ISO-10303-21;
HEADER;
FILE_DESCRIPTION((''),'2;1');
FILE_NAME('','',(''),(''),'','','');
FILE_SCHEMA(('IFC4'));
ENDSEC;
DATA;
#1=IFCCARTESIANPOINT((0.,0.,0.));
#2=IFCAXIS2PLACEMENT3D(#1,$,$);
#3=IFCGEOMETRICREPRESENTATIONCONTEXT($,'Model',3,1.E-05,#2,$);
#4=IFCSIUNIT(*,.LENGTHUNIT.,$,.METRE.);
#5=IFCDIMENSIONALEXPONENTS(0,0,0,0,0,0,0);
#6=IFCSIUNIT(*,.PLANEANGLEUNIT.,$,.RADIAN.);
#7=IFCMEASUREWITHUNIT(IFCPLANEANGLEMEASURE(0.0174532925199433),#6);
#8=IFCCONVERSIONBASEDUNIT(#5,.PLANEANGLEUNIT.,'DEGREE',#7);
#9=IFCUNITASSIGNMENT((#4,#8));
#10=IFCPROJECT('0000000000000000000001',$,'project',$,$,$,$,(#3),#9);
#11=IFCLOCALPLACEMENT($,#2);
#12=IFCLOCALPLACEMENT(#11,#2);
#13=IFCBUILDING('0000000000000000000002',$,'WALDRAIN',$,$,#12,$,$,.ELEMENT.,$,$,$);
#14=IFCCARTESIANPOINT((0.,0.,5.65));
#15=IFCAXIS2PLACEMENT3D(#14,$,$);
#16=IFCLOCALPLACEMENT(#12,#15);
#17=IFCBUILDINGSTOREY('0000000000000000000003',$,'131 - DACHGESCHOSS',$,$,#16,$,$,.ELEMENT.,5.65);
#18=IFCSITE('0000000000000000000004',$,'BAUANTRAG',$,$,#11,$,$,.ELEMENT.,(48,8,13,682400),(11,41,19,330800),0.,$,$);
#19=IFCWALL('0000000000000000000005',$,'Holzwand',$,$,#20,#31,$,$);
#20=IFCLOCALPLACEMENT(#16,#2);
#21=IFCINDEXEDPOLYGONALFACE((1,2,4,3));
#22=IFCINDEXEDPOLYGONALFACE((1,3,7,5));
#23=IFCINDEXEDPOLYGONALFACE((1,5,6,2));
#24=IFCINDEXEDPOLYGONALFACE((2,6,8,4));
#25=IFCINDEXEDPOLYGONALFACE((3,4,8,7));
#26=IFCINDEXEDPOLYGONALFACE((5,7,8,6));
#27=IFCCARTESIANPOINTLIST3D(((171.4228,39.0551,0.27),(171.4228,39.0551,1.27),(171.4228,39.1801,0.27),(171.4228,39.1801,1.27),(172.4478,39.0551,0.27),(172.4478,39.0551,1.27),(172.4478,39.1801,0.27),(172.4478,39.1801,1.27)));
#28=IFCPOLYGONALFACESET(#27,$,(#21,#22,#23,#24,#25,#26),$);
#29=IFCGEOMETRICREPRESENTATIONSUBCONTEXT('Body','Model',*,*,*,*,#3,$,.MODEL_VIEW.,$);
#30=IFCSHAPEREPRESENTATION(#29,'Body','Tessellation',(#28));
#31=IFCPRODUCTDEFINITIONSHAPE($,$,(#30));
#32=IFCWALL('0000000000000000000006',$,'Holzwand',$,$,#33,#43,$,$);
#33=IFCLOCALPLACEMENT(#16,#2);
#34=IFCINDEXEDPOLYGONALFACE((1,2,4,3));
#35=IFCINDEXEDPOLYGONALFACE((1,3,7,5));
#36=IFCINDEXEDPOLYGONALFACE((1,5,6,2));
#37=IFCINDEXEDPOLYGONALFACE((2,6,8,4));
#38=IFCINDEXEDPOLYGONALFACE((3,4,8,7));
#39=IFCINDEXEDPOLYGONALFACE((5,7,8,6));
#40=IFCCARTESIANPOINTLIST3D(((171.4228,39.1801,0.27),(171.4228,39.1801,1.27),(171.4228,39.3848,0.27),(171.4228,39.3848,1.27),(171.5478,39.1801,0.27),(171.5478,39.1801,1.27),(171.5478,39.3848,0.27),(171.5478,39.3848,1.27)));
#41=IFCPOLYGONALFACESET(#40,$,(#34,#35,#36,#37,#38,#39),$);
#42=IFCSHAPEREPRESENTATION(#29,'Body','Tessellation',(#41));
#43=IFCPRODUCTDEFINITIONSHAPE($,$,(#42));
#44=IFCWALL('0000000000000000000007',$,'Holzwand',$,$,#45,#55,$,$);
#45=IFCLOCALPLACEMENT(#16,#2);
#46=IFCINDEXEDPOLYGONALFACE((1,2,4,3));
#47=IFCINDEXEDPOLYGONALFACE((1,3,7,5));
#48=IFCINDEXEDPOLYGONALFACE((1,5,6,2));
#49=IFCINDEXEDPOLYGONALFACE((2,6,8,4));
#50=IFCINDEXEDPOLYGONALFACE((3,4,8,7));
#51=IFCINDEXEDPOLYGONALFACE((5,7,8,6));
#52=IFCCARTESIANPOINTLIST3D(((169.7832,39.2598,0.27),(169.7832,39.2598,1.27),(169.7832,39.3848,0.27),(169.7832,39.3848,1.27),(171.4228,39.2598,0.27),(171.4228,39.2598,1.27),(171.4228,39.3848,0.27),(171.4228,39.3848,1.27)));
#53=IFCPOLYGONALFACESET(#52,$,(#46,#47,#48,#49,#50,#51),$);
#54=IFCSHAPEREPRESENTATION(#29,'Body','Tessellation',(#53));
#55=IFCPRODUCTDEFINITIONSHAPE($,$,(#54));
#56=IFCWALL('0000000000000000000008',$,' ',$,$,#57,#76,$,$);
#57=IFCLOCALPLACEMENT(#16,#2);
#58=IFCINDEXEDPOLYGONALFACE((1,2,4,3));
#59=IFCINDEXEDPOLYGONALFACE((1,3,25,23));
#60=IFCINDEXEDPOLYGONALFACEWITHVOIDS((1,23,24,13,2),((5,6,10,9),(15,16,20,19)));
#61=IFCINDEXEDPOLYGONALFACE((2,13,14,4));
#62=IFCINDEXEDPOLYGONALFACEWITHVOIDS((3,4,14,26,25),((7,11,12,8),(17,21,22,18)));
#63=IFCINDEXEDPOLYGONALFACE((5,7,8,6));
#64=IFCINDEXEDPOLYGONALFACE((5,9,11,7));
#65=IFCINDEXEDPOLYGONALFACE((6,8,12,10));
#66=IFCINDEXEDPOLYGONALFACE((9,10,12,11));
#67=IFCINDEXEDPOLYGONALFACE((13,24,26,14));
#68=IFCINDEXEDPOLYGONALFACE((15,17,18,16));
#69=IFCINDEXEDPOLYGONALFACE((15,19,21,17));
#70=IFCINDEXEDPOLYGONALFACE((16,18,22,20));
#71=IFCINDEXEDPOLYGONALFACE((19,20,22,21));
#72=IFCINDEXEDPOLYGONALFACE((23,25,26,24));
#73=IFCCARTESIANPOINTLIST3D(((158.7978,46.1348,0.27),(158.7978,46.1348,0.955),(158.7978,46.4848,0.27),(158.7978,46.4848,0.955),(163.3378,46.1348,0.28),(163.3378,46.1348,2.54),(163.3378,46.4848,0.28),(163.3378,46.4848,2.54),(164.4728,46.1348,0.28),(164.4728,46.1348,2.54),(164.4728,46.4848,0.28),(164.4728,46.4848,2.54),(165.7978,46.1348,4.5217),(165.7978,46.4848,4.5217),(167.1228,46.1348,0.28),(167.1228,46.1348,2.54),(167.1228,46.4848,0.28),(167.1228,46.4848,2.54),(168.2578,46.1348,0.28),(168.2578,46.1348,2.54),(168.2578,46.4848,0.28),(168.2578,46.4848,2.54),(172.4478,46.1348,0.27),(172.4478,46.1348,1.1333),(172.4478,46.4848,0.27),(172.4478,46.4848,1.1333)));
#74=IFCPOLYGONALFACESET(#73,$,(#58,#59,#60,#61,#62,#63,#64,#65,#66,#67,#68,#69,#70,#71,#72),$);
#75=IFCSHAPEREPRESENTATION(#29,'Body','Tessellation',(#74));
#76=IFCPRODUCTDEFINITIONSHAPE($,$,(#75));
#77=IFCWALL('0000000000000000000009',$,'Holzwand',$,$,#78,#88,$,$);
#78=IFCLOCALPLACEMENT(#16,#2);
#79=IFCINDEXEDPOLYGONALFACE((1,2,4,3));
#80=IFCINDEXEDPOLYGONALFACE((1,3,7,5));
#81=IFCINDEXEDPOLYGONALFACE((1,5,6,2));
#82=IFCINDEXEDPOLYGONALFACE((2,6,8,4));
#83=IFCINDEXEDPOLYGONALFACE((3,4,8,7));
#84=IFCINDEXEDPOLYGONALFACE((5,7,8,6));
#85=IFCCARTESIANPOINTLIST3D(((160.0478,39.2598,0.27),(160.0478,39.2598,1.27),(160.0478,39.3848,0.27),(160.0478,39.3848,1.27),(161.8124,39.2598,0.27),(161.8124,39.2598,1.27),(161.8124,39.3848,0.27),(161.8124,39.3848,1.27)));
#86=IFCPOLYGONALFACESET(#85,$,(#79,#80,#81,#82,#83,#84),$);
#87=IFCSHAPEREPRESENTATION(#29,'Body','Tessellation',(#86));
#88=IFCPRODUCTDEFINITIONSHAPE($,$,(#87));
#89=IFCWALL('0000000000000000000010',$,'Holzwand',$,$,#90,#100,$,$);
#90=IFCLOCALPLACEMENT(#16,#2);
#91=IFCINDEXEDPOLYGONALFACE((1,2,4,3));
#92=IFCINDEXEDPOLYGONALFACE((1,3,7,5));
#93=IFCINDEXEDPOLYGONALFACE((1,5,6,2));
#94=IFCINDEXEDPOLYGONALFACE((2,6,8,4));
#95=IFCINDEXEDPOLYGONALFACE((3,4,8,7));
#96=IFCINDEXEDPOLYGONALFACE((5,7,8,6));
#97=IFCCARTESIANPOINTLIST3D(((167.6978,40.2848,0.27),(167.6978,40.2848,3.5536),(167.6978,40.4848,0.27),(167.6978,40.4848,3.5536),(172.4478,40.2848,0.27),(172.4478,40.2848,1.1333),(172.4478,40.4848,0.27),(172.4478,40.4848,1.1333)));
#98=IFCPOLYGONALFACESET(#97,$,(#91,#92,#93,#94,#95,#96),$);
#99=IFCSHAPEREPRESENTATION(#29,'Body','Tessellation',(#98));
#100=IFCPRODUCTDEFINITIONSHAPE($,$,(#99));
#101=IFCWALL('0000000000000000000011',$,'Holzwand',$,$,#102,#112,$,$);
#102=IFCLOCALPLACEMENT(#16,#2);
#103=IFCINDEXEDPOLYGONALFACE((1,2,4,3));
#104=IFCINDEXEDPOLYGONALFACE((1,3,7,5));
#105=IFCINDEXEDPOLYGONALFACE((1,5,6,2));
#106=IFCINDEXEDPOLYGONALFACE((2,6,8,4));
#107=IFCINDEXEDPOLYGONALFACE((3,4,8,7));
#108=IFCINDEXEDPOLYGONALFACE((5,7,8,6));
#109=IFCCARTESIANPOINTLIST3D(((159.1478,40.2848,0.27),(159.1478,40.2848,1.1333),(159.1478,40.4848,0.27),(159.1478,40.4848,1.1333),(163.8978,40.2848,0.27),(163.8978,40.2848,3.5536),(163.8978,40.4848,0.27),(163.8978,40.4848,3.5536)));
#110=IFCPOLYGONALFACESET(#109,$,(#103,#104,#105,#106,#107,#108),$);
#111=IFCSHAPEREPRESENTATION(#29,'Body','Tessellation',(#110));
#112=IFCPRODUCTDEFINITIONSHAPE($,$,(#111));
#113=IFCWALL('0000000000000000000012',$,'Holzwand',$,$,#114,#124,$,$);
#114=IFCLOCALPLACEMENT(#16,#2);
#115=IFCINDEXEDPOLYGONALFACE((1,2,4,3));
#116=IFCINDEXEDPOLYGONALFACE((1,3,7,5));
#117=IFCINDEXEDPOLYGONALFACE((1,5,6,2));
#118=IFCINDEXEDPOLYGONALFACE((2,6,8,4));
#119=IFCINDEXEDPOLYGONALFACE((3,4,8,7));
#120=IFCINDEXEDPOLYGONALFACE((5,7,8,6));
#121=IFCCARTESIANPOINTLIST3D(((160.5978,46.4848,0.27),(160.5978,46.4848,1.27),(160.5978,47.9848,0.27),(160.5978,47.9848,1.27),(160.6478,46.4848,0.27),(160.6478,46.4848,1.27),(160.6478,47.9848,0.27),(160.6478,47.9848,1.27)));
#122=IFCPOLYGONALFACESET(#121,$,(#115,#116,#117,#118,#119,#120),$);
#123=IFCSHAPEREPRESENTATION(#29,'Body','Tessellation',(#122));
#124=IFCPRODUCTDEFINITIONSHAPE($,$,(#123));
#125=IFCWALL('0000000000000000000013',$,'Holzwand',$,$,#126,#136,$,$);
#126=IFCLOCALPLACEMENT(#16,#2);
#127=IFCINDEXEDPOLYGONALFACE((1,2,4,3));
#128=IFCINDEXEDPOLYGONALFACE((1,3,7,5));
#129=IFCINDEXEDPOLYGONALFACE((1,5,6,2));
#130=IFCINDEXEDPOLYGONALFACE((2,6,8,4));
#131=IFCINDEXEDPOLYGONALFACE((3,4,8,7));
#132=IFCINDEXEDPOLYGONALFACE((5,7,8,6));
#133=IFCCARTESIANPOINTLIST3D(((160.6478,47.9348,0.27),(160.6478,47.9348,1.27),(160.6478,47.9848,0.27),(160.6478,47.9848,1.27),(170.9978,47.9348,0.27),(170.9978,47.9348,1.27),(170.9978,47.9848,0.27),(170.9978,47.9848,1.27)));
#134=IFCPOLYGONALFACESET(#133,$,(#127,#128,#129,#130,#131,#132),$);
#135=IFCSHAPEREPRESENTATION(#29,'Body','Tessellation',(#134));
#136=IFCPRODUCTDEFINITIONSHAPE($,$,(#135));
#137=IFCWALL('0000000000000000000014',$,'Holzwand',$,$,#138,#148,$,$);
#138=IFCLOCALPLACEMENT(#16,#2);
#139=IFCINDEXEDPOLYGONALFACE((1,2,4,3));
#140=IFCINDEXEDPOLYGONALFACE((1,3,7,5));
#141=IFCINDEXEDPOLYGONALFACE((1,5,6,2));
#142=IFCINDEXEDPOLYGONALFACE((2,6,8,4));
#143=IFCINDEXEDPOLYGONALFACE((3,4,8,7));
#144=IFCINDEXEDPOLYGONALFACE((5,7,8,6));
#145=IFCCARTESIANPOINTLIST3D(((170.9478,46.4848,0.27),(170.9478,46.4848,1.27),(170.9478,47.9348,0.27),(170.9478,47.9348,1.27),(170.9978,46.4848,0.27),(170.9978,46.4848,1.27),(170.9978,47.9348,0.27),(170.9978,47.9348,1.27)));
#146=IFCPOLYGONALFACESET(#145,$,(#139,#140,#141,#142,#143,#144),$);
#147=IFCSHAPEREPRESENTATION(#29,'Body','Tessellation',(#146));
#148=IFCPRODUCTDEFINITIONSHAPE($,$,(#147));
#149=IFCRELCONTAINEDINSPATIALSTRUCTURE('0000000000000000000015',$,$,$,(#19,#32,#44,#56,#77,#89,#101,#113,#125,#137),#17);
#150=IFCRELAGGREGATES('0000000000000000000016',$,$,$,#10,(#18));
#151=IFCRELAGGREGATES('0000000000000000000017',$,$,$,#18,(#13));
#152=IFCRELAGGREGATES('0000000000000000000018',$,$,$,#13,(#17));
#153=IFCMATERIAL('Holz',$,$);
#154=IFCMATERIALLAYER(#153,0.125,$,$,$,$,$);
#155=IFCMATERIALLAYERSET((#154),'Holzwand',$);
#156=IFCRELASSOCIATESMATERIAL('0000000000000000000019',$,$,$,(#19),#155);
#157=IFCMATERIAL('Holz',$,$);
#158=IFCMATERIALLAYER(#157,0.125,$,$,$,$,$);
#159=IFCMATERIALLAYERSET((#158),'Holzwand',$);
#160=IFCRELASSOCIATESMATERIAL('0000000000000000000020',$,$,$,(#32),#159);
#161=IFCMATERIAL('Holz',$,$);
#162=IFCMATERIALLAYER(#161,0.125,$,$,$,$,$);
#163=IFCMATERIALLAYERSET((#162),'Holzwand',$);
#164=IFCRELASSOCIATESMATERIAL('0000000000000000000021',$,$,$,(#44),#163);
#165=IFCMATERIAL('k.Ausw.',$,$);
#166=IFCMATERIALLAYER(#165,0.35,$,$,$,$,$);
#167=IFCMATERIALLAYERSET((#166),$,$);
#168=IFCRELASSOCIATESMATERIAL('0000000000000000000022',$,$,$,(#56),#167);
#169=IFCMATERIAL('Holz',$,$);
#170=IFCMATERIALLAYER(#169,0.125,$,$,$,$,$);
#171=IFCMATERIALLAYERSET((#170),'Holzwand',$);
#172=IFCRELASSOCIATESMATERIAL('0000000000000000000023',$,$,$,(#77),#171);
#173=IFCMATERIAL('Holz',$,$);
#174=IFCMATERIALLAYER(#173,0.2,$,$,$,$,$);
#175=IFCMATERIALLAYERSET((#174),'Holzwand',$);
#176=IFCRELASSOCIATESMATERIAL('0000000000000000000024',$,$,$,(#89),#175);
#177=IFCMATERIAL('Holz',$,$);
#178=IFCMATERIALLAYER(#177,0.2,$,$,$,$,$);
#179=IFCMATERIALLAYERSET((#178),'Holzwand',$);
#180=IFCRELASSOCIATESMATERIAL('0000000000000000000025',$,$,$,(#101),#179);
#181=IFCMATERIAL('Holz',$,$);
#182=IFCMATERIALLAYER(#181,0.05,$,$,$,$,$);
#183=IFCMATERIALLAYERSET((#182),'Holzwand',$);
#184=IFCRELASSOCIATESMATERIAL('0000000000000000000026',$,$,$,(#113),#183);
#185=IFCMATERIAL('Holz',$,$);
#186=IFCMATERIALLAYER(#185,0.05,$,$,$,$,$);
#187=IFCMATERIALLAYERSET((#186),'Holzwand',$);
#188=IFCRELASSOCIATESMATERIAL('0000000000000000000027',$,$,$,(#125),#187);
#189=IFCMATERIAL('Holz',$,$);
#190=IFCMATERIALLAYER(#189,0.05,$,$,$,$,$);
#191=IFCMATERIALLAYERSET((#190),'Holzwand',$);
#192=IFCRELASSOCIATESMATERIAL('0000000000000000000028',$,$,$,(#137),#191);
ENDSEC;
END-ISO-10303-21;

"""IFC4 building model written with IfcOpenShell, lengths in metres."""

from ifc_helpers import new_model, entity, si_unit, converted_unit, frame, frame_2d, origin, origin_with_axes, place, context, subcontext, project, spatial, polyline, rectangle, outline, extrude, clip, halfspace, bounded_halfspace, material, layer, layer_set, layer_usage, element, save


model = new_model("IFC4")

# Units and contexts
model_context = context("Model", 3, precision=1e-05, world=origin())
body_context = subcontext(model_context, "Body", "Model", "MODEL_VIEW")
ifc_project = project(units=[si_unit("LENGTHUNIT", "METRE"), converted_unit("PLANEANGLEUNIT", "DEGREE", entity("IfcPlaneAngleMeasure", 0.0174532925199433), si_unit("PLANEANGLEUNIT", "RADIAN"), dimensions=[0, 0, 0, 0, 0, 0, 0])], contexts=[model_context])

# Site, building, storey
site_placement = place(None, origin())
site = spatial("IfcSite", under=ifc_project, at=site_placement, Name="BAUANTRAG", CompositionType="ELEMENT", RefLatitude=(48, 8, 13, 682400), RefLongitude=(11, 41, 19, 330800), RefElevation=0.0)
building_placement = place(site_placement, origin())
building = spatial("IfcBuilding", under=site, at=building_placement, Name="WALDRAIN", CompositionType="ELEMENT")
storey_placement = place(building_placement, frame((0.0, 0.0, 5.65)))
storey = spatial("IfcBuildingStorey", under=building, at=storey_placement, Name="131 - DACHGESCHOSS", CompositionType="ELEMENT", Elevation=5.65)

# Walls
ifc_material_1 = material(Name="Holz")
ifc_layer_1 = layer(ifc_material_1, 0.125)
ifc_layer_set_1 = layer_set([ifc_layer_1], Name="Holzwand")
ifc_layer_usage_1 = layer_usage(ifc_layer_set_1, "AXIS2", "POSITIVE", 0.0)
wall_1_placement = place(storey_placement, frame((172.4478, 39.1801, 0.27), z_axis=(0.0, 0.0, 1.0), x_axis=(-1.0, 0.0, 0.0)))
element("IfcWall", 1, at=wall_1_placement, inside=storey, material=ifc_layer_usage_1, Name="Holzwand", context=body_context, shape_type="SweptSolid", body=[
    extrude(rectangle(XDim=1.025, YDim=0.125, at=frame_2d((0.5125, 0.0625), x_axis=(1.0, 0.0))), origin_with_axes(), (0.0, 0.0, 1.0), 1.0),
])
ifc_material_2 = material(Name="Holz")
ifc_layer_2 = layer(ifc_material_2, 0.125)
ifc_layer_set_2 = layer_set([ifc_layer_2], Name="Holzwand")
ifc_layer_usage_2 = layer_usage(ifc_layer_set_2, "AXIS2", "POSITIVE", 0.0)
wall_2_placement = place(storey_placement, frame((171.5478, 39.1801, 0.27), z_axis=(0.0, 0.0, 1.0), x_axis=(0.0, 1.0, 0.0)))
element("IfcWall", 2, at=wall_2_placement, inside=storey, material=ifc_layer_usage_2, Name="Holzwand", context=body_context, shape_type="SweptSolid", body=[
    extrude(rectangle(XDim=0.2047, YDim=0.125, at=frame_2d((0.1024, 0.0625), x_axis=(1.0, 0.0))), origin_with_axes(), (0.0, 0.0, 1.0), 1.0),
])
ifc_material_3 = material(Name="Holz")
ifc_layer_3 = layer(ifc_material_3, 0.125)
ifc_layer_set_3 = layer_set([ifc_layer_3], Name="Holzwand")
ifc_layer_usage_3 = layer_usage(ifc_layer_set_3, "AXIS2", "POSITIVE", 0.0)
wall_3_placement = place(storey_placement, frame((171.4228, 39.3848, 0.27), z_axis=(0.0, 0.0, 1.0), x_axis=(-1.0, 0.0, 0.0)))
element("IfcWall", 3, at=wall_3_placement, inside=storey, material=ifc_layer_usage_3, Name="Holzwand", context=body_context, shape_type="SweptSolid", body=[
    extrude(rectangle(XDim=1.6396, YDim=0.125, at=frame_2d((0.8198, 0.0625), x_axis=(1.0, 0.0))), origin_with_axes(), (0.0, 0.0, 1.0), 1.0),
])

# Wall, openings
ifc_material_4 = material(Name="k.Ausw.")
ifc_layer_4 = layer(ifc_material_4, 0.35)
ifc_layer_set_4 = layer_set([ifc_layer_4])
ifc_layer_usage_4 = layer_usage(ifc_layer_set_4, "AXIS2", "POSITIVE", 0.0)
wall_4_placement = place(storey_placement, frame((172.4478, 46.4848, 0.27), z_axis=(0.0, 0.0, 1.0), x_axis=(-1.0, 0.0, 0.0)))
wall_4 = element("IfcWall", 4, at=wall_4_placement, inside=storey, material=ifc_layer_usage_4, Name=" ", context=body_context, shape_type="Clipping", body=[
    clip(clip(extrude(rectangle(XDim=13.65, YDim=0.35, at=frame_2d((6.825, 0.175), x_axis=(1.0, 0.0))), origin_with_axes(), (0.0, 0.0, 1.0), 4.2517), bounded_halfspace(frame((10.15, 0.175, 2.4683), z_axis=(-0.45399, 0.0, -0.891007), x_axis=(0.0, -1.0, 0.0)), True, origin_with_axes(), polyline([(6.65, 0.35), (6.65, 0.0), (13.65, 0.0), (13.65, 0.35), (6.65, 0.35)]))), bounded_halfspace(frame((3.325, 0.175, 2.5575), z_axis=(0.45399, 0.0, -0.891007), x_axis=(0.0, -1.0, 0.0)), True, origin_with_axes(), polyline([(0.0, 0.35), (0.0, 0.0), (6.65, 0.0), (6.65, 0.35), (0.0, 0.35)]))),
])
opening_1_placement = place(wall_4_placement, frame((5.325, 0.35, 0.01), z_axis=(0.0, -1.0, 0.0), x_axis=(0.0, 0.0, 1.0)))
element("IfcOpeningElement", 5, at=opening_1_placement, cuts=wall_4, ObjectType="Opening", context=body_context, shape_type="SweptSolid", body=[
    extrude(outline(polyline([(0.0, 1.135), (2.26, 1.135), (2.26, 0.0), (0.0, 0.0), (0.0, 1.135)])), origin_with_axes(), (0.0, 0.0, 1.0), 0.35),
])
opening_2_placement = place(wall_4_placement, frame((9.11, 0.35, 0.01), z_axis=(0.0, -1.0, 0.0), x_axis=(0.0, 0.0, 1.0)))
element("IfcOpeningElement", 6, at=opening_2_placement, cuts=wall_4, ObjectType="Opening", context=body_context, shape_type="SweptSolid", body=[
    extrude(outline(polyline([(0.0, 1.135), (2.26, 1.135), (2.26, 0.0), (0.0, 0.0), (0.0, 1.135)])), origin_with_axes(), (0.0, 0.0, 1.0), 0.35),
])

# Walls
ifc_material_5 = material(Name="Holz")
ifc_layer_5 = layer(ifc_material_5, 0.125)
ifc_layer_set_5 = layer_set([ifc_layer_5], Name="Holzwand")
ifc_layer_usage_5 = layer_usage(ifc_layer_set_5, "AXIS2", "POSITIVE", 0.0)
wall_5_placement = place(storey_placement, frame((161.8124, 39.3848, 0.27), z_axis=(0.0, 0.0, 1.0), x_axis=(-1.0, 0.0, 0.0)))
element("IfcWall", 7, at=wall_5_placement, inside=storey, material=ifc_layer_usage_5, Name="Holzwand", context=body_context, shape_type="SweptSolid", body=[
    extrude(rectangle(XDim=1.7646, YDim=0.125, at=frame_2d((0.8823, 0.0625), x_axis=(1.0, 0.0))), origin_with_axes(), (0.0, 0.0, 1.0), 1.0),
])
ifc_material_6 = material(Name="Holz")
ifc_layer_6 = layer(ifc_material_6, 0.2)
ifc_layer_set_6 = layer_set([ifc_layer_6], Name="Holzwand")
ifc_layer_usage_6 = layer_usage(ifc_layer_set_6, "AXIS2", "POSITIVE", 0.0)
wall_6_placement = place(storey_placement, frame((172.4478, 40.4848, 0.27), z_axis=(0.0, 0.0, 1.0), x_axis=(-1.0, 0.0, 0.0)))
element("IfcWall", 8, at=wall_6_placement, inside=storey, material=ifc_layer_usage_6, Name="Holzwand", context=body_context, shape_type="Clipping", body=[
    clip(extrude(rectangle(XDim=4.75, YDim=0.2, at=frame_2d((2.375, 0.1), x_axis=(1.0, 0.0))), origin_with_axes(), (0.0, 0.0, 1.0), 3.2836), halfspace(frame((2.375, 0.1, 2.0735), z_axis=(0.45399, 0.0, -0.891007), x_axis=(0.891007, 0.0, 0.45399)), True)),
])
ifc_material_7 = material(Name="Holz")
ifc_layer_7 = layer(ifc_material_7, 0.2)
ifc_layer_set_7 = layer_set([ifc_layer_7], Name="Holzwand")
ifc_layer_usage_7 = layer_usage(ifc_layer_set_7, "AXIS2", "POSITIVE", 0.0)
wall_7_placement = place(storey_placement, frame((163.8978, 40.4848, 0.27), z_axis=(0.0, 0.0, 1.0), x_axis=(-1.0, 0.0, 0.0)))
element("IfcWall", 9, at=wall_7_placement, inside=storey, material=ifc_layer_usage_7, Name="Holzwand", context=body_context, shape_type="Clipping", body=[
    clip(extrude(rectangle(XDim=4.75, YDim=0.2, at=frame_2d((2.375, 0.1), x_axis=(1.0, 0.0))), origin_with_axes(), (0.0, 0.0, 1.0), 3.2836), halfspace(frame((2.375, 0.1, 2.0735), z_axis=(-0.45399, 0.0, -0.891007), x_axis=(0.891007, 0.0, -0.45399)), True)),
])
ifc_material_8 = material(Name="Holz")
ifc_layer_8 = layer(ifc_material_8, 0.05)
ifc_layer_set_8 = layer_set([ifc_layer_8], Name="Holzwand")
ifc_layer_usage_8 = layer_usage(ifc_layer_set_8, "AXIS2", "POSITIVE", 0.0)
wall_8_placement = place(storey_placement, frame((160.5978, 47.9848, 0.27), z_axis=(0.0, 0.0, 1.0), x_axis=(0.0, -1.0, 0.0)))
element("IfcWall", 10, at=wall_8_placement, inside=storey, material=ifc_layer_usage_8, Name="Holzwand", context=body_context, shape_type="SweptSolid", body=[
    extrude(rectangle(XDim=1.5, YDim=0.05, at=frame_2d((0.75, 0.025), x_axis=(1.0, 0.0))), origin_with_axes(), (0.0, 0.0, 1.0), 1.0),
])
ifc_material_9 = material(Name="Holz")
ifc_layer_9 = layer(ifc_material_9, 0.05)
ifc_layer_set_9 = layer_set([ifc_layer_9], Name="Holzwand")
ifc_layer_usage_9 = layer_usage(ifc_layer_set_9, "AXIS2", "POSITIVE", 0.0)
wall_9_placement = place(storey_placement, frame((170.9978, 47.9848, 0.27), z_axis=(0.0, 0.0, 1.0), x_axis=(-1.0, 0.0, 0.0)))
element("IfcWall", 11, at=wall_9_placement, inside=storey, material=ifc_layer_usage_9, Name="Holzwand", context=body_context, shape_type="SweptSolid", body=[
    extrude(rectangle(XDim=10.35, YDim=0.05, at=frame_2d((5.175, 0.025), x_axis=(1.0, 0.0))), origin_with_axes(), (0.0, 0.0, 1.0), 1.0),
])
ifc_material_10 = material(Name="Holz")
ifc_layer_10 = layer(ifc_material_10, 0.05)
ifc_layer_set_10 = layer_set([ifc_layer_10], Name="Holzwand")
ifc_layer_usage_10 = layer_usage(ifc_layer_set_10, "AXIS2", "POSITIVE", 0.0)
wall_10_placement = place(storey_placement, frame((170.9978, 46.4848, 0.27), z_axis=(0.0, 0.0, 1.0), x_axis=(0.0, 1.0, 0.0)))
element("IfcWall", 12, at=wall_10_placement, inside=storey, material=ifc_layer_usage_10, Name="Holzwand", context=body_context, shape_type="SweptSolid", body=[
    extrude(rectangle(XDim=1.45, YDim=0.05, at=frame_2d((0.725, 0.025), x_axis=(1.0, 0.0))), origin_with_axes(), (0.0, 0.0, 1.0), 1.0),
])

save(model, "model.ifc")
